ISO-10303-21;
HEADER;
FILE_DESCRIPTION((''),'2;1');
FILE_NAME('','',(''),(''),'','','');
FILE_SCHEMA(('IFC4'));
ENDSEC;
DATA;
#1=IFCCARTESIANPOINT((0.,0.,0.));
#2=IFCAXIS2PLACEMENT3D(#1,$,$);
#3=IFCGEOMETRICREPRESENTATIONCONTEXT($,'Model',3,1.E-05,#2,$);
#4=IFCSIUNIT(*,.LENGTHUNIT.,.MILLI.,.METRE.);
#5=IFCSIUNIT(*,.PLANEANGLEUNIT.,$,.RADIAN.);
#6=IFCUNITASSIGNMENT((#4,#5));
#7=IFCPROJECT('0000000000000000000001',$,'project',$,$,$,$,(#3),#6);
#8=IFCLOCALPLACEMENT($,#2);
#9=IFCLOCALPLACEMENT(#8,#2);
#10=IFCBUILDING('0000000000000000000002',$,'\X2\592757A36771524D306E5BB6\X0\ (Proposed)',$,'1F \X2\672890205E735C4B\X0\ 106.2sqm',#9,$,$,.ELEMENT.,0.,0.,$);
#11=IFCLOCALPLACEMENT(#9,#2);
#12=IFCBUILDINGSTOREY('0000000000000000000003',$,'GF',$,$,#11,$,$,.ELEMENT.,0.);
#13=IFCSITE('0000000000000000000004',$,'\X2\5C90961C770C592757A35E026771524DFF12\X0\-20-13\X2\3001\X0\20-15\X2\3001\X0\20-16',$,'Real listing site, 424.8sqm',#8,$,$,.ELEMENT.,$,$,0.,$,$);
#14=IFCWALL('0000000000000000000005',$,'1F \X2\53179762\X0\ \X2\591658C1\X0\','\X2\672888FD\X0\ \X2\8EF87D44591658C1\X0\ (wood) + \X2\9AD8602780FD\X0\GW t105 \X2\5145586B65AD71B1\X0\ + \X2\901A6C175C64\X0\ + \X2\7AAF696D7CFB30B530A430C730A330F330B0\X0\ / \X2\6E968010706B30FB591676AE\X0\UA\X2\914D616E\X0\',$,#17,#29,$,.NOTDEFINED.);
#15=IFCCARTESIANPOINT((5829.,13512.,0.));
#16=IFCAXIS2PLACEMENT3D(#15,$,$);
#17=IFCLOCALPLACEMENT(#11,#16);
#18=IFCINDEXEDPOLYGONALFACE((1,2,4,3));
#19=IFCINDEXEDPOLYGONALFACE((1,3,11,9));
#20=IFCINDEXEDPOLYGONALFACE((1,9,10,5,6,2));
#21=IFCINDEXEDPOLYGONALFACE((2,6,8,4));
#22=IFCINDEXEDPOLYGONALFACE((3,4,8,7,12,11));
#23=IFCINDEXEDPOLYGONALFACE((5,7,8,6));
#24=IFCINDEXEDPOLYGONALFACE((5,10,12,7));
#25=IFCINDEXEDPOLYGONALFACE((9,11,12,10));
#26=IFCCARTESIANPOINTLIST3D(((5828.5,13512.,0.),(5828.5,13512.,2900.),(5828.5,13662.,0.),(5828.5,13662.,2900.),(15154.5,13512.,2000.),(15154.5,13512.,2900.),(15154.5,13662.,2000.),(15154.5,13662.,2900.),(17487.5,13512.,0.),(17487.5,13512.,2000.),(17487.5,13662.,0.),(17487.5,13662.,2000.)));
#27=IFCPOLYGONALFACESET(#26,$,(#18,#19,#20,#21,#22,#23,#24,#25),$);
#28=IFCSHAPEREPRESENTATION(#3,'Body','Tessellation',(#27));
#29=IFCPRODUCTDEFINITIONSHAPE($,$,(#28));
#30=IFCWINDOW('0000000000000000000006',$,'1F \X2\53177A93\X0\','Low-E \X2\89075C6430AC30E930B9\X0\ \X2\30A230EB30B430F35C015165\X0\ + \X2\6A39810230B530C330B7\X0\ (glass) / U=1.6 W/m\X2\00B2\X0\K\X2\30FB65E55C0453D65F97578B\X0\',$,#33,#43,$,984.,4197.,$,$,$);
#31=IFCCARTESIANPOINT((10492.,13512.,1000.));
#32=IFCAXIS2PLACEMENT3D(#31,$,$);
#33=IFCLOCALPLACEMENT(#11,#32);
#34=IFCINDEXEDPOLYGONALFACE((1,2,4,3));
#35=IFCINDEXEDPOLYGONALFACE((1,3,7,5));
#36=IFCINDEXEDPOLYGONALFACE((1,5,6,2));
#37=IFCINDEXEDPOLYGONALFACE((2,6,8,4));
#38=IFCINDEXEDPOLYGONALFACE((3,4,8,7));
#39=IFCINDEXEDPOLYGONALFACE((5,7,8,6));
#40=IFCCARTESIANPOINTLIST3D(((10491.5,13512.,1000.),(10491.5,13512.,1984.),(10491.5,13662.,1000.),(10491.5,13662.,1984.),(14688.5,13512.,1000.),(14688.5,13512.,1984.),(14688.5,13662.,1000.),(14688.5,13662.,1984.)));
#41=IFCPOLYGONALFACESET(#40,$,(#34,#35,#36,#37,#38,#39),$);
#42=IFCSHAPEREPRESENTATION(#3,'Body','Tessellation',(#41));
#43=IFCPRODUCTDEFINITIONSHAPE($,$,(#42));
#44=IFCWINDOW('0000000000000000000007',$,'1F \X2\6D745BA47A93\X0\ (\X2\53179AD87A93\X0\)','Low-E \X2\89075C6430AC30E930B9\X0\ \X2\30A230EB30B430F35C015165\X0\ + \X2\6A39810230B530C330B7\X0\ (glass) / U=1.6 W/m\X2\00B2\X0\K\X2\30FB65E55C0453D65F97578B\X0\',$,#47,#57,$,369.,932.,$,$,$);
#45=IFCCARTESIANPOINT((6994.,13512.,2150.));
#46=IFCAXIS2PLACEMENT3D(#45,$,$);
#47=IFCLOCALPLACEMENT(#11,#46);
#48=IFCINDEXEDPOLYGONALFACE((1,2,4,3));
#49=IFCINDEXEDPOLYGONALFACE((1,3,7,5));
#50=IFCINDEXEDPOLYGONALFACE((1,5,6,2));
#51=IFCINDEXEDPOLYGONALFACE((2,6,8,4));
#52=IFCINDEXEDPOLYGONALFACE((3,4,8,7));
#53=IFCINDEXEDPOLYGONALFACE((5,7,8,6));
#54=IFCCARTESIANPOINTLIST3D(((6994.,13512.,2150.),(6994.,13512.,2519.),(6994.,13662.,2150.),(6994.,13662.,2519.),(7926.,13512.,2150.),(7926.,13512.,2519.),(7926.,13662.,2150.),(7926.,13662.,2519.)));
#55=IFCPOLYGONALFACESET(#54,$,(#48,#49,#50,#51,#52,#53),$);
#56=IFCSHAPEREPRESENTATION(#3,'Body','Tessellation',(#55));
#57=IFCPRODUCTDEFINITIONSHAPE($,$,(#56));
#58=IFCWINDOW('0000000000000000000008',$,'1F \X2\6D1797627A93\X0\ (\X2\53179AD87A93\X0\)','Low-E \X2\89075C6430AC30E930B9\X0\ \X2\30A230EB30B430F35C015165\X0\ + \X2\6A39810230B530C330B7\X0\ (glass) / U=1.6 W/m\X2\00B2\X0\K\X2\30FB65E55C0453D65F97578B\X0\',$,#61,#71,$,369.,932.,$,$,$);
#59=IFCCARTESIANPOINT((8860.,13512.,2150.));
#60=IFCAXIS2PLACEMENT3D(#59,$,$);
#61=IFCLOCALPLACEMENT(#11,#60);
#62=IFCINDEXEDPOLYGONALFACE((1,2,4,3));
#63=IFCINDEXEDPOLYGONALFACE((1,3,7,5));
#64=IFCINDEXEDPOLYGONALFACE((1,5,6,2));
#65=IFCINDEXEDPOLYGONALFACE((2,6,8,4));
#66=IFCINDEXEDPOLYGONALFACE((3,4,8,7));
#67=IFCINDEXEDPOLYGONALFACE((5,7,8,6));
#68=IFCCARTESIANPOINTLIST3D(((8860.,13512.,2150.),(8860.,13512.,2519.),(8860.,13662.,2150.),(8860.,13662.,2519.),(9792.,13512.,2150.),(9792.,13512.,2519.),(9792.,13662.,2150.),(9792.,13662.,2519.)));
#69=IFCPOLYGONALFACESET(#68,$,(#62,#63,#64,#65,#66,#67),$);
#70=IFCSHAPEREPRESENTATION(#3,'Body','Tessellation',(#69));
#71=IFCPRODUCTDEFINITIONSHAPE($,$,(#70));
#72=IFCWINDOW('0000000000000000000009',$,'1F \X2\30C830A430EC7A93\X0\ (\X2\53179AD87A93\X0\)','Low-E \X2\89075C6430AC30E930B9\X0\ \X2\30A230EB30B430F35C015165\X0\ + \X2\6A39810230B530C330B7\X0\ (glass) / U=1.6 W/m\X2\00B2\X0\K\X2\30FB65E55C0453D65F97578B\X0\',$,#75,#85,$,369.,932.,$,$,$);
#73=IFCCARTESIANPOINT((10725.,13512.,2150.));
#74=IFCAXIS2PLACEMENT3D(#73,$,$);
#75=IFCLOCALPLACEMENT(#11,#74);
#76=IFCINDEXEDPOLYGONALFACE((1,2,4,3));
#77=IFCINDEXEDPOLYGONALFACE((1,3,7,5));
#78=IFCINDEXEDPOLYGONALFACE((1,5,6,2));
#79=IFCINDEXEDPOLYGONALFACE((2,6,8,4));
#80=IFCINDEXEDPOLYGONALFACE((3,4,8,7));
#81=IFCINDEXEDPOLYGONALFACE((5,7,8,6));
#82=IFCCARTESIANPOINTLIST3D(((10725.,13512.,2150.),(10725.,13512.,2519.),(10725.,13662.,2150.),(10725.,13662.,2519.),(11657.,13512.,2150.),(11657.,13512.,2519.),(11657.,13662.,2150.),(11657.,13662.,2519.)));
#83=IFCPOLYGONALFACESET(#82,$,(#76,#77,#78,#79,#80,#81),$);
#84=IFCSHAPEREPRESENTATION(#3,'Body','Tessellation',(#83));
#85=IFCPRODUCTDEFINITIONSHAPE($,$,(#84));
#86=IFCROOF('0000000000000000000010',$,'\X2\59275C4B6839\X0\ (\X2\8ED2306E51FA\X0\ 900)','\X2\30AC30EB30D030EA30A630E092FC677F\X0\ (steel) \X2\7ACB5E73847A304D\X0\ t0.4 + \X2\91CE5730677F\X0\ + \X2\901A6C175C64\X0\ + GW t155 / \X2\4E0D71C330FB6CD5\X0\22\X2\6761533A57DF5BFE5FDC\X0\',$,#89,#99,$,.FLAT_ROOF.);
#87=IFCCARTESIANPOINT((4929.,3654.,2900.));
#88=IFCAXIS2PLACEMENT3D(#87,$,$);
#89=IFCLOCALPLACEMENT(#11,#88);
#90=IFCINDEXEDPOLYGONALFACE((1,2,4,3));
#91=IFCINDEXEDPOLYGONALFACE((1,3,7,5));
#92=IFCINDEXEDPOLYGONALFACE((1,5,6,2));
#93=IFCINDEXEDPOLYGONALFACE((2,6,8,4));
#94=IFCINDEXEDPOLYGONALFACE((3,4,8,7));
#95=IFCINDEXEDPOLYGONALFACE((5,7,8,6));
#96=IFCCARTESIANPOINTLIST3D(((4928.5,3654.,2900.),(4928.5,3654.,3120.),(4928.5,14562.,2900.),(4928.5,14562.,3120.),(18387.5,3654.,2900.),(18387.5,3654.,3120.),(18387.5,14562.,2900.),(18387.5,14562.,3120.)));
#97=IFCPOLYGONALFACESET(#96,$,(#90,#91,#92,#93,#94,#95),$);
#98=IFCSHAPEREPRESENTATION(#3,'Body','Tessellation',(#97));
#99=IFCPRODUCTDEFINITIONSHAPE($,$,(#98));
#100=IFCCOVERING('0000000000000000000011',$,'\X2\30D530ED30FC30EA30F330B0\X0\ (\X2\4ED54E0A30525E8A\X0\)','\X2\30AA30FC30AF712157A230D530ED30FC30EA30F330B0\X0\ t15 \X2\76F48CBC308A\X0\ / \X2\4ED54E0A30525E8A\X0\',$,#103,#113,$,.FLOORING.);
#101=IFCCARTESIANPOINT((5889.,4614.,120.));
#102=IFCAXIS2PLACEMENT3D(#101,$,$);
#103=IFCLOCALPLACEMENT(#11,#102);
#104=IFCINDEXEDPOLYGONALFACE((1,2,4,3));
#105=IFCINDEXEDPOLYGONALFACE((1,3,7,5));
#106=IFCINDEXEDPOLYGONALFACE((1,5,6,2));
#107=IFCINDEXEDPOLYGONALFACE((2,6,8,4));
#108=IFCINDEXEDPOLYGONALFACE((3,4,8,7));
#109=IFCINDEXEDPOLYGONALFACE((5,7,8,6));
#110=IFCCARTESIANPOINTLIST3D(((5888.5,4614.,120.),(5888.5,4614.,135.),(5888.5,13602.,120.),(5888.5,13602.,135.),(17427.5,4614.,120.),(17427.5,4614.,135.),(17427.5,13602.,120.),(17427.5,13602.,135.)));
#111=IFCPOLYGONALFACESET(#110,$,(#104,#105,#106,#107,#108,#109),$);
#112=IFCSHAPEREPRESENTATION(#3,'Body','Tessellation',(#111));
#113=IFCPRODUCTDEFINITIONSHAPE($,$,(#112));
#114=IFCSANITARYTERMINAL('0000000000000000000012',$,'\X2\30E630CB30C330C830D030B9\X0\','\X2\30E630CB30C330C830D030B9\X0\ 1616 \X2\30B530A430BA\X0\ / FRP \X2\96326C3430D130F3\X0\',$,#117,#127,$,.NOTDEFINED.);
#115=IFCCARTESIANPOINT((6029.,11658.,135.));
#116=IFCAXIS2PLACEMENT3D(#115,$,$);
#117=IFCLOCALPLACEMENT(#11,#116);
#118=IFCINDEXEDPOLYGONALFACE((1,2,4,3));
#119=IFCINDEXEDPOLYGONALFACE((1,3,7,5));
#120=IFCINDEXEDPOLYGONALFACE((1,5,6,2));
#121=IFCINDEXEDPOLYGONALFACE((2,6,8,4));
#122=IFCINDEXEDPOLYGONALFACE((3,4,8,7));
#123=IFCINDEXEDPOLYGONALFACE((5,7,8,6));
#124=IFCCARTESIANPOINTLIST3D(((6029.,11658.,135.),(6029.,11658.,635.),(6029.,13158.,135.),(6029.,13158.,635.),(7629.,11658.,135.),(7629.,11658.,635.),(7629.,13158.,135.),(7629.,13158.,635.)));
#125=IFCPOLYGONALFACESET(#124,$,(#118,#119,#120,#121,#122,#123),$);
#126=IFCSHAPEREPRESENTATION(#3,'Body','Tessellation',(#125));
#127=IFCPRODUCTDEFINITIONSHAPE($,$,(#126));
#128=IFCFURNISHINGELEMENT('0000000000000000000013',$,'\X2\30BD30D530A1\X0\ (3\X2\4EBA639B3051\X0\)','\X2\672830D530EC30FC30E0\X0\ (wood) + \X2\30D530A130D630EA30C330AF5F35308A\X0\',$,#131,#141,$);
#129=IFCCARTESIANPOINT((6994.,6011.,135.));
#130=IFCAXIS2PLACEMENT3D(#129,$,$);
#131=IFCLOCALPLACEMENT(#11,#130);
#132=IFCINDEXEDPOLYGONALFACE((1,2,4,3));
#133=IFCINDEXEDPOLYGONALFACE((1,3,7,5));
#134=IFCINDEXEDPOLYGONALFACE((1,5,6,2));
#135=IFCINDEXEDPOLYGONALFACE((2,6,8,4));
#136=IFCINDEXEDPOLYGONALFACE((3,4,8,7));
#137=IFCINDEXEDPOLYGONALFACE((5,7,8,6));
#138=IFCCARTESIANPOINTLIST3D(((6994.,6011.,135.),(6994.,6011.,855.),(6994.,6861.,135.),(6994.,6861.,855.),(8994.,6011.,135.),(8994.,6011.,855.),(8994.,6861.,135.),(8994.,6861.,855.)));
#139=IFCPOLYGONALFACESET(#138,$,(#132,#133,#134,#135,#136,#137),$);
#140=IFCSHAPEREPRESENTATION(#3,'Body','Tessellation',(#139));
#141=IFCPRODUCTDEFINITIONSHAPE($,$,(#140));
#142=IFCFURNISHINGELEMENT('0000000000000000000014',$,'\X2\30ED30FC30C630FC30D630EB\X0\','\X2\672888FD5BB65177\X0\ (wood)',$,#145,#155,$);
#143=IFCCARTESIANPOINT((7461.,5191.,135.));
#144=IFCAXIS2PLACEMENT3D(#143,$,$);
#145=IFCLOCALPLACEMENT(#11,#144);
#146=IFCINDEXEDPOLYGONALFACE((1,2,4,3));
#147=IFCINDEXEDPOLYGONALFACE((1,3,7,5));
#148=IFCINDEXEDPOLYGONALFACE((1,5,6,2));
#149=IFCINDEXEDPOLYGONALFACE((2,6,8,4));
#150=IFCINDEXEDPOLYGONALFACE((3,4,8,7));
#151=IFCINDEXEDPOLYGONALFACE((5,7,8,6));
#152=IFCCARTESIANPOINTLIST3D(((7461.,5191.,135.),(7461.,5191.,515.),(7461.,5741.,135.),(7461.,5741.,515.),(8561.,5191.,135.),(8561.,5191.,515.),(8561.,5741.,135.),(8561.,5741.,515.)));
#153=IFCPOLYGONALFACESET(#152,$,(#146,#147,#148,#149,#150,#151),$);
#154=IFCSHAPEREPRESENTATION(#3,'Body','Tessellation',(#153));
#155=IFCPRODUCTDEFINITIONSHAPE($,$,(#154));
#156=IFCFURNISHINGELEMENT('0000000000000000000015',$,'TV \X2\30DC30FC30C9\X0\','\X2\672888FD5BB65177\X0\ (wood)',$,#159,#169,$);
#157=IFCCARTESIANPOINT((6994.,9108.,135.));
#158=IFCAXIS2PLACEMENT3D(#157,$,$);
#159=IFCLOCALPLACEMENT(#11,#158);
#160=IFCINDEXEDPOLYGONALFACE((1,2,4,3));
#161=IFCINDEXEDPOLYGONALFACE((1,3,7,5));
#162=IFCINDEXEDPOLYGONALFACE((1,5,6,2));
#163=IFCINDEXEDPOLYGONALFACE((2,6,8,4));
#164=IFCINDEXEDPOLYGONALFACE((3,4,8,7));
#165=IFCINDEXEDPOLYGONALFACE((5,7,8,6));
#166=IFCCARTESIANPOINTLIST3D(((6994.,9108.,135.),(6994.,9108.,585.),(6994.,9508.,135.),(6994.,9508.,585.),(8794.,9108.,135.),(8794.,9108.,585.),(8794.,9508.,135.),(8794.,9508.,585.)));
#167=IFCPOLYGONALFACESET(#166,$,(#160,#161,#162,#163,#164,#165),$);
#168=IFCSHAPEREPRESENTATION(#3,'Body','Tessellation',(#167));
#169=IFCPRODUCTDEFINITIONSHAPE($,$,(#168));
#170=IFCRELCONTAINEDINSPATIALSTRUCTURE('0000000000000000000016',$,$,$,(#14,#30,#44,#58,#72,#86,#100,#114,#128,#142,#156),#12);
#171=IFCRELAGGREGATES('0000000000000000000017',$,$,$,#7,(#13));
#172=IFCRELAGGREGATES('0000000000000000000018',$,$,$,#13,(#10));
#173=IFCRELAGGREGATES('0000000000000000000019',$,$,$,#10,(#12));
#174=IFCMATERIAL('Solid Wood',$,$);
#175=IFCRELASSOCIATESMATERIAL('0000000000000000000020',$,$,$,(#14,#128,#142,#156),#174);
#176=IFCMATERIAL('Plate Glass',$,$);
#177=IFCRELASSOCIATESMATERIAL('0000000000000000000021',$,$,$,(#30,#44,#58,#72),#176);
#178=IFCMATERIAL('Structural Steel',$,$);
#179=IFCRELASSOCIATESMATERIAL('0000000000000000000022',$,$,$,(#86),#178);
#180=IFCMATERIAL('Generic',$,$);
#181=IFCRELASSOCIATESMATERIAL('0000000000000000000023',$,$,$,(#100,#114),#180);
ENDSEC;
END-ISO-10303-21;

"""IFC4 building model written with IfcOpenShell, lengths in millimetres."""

from ifc_helpers import new_model, si_unit, frame, frame_2d, origin, place, context, project, spatial, rectangle, extrude, material, element, fill, save


model = new_model("IFC4")

# Units and contexts
model_context = context("Model", 3, precision=1e-05, world=origin())
ifc_project = project(units=[si_unit("LENGTHUNIT", "METRE", prefix="MILLI"), si_unit("PLANEANGLEUNIT", "RADIAN")], contexts=[model_context])

# Site, building, storey
site_placement = place(None, origin())
site = spatial("IfcSite", under=ifc_project, at=site_placement, Name="岐阜県大垣市東前２-20-13、20-15、20-16", ObjectType="Real listing site, 424.8sqm", CompositionType="ELEMENT", RefElevation=0.0)
building_placement = place(site_placement, origin())
building = spatial("IfcBuilding", under=site, at=building_placement, Name="大垣東前の家 (Proposed)", ObjectType="1F 木造平屋 106.2sqm", CompositionType="ELEMENT", ElevationOfRefHeight=0.0, ElevationOfTerrain=0.0)
storey_placement = place(building_placement, origin())
storey = spatial("IfcBuildingStorey", under=building, at=storey_placement, Name="GF", CompositionType="ELEMENT", Elevation=0.0)

# Shared definitions
ifc_material_1 = material(Name="Solid Wood")

# Shared definitions
ifc_material_2 = material(Name="Plate Glass")

# Wall, openings, windows
wall_1_placement = place(storey_placement, frame((5829.0, 13512.0, 0.0)))
wall_1 = element("IfcWall", 1, at=wall_1_placement, inside=storey, material=ifc_material_1, Name="1F 北面 外壁", Description="木製 軸組外壁 (wood) + 高性能GW t105 充填断熱 + 通気層 + 窯業系サイディング / 準耐火・外皮UA配慮", PredefinedType="NOTDEFINED", context=model_context, shape_type="SweptSolid", body=[
    extrude(rectangle(XDim=11659.0, YDim=150.0, at=frame_2d((5829.0, 75.0))), frame((5829.0, 13512.0, 0.0)), (0.0, 0.0, 1.0), 2900.0),
])
opening_1_placement = place(storey_placement, frame((10492.0, 13512.0, 1000.0)))
opening_1 = element("IfcOpeningElement", 2, at=opening_1_placement, cuts=wall_1, PredefinedType="NOTDEFINED", context=model_context, shape_type="SweptSolid", body=[
    extrude(rectangle(XDim=4197.0, YDim=150.0, at=frame_2d((2098.0, 75.0))), frame((10492.0, 13512.0, 1000.0)), (0.0, 0.0, 1.0), 984.0),
])
opening_2_placement = place(storey_placement, frame((6994.0, 13512.0, 2150.0)))
opening_2 = element("IfcOpeningElement", 3, at=opening_2_placement, cuts=wall_1, PredefinedType="NOTDEFINED", context=model_context, shape_type="SweptSolid", body=[
    extrude(rectangle(XDim=932.0, YDim=150.0, at=frame_2d((466.0, 75.0))), frame((6994.0, 13512.0, 2150.0)), (0.0, 0.0, 1.0), 369.0),
])
opening_3_placement = place(storey_placement, frame((8860.0, 13512.0, 2150.0)))
opening_3 = element("IfcOpeningElement", 4, at=opening_3_placement, cuts=wall_1, PredefinedType="NOTDEFINED", context=model_context, shape_type="SweptSolid", body=[
    extrude(rectangle(XDim=932.0, YDim=150.0, at=frame_2d((466.0, 75.0))), frame((8860.0, 13512.0, 2150.0)), (0.0, 0.0, 1.0), 369.0),
])
opening_4_placement = place(storey_placement, frame((10725.0, 13512.0, 2150.0)))
opening_4 = element("IfcOpeningElement", 5, at=opening_4_placement, cuts=wall_1, PredefinedType="NOTDEFINED", context=model_context, shape_type="SweptSolid", body=[
    extrude(rectangle(XDim=932.0, YDim=150.0, at=frame_2d((466.0, 75.0))), frame((10725.0, 13512.0, 2150.0)), (0.0, 0.0, 1.0), 369.0),
])
window_1_placement = place(storey_placement, frame((10492.0, 13512.0, 1000.0)))
window_1 = element("IfcWindow", 6, at=window_1_placement, inside=storey, material=ifc_material_2, Name="1F 北窓", Description="Low-E 複層ガラス アルゴン封入 + 樹脂サッシ (glass) / U=1.6 W/m²K・日射取得型", OverallHeight=984.0, OverallWidth=4197.0, context=model_context, shape_type="SweptSolid", body=[
    extrude(rectangle(XDim=4197.0, YDim=150.0, at=frame_2d((2098.0, 75.0))), frame((10492.0, 13512.0, 1000.0)), (0.0, 0.0, 1.0), 984.0),
])
fill(opening_1, window_1)
window_2_placement = place(storey_placement, frame((6994.0, 13512.0, 2150.0)))
window_2 = element("IfcWindow", 7, at=window_2_placement, inside=storey, material=ifc_material_2, Name="1F 浴室窓 (北高窓)", Description="Low-E 複層ガラス アルゴン封入 + 樹脂サッシ (glass) / U=1.6 W/m²K・日射取得型", OverallHeight=369.0, OverallWidth=932.0, context=model_context, shape_type="SweptSolid", body=[
    extrude(rectangle(XDim=932.0, YDim=150.0, at=frame_2d((466.0, 75.0))), frame((6994.0, 13512.0, 2150.0)), (0.0, 0.0, 1.0), 369.0),
])
fill(opening_2, window_2)
window_3_placement = place(storey_placement, frame((8860.0, 13512.0, 2150.0)))
window_3 = element("IfcWindow", 8, at=window_3_placement, inside=storey, material=ifc_material_2, Name="1F 洗面窓 (北高窓)", Description="Low-E 複層ガラス アルゴン封入 + 樹脂サッシ (glass) / U=1.6 W/m²K・日射取得型", OverallHeight=369.0, OverallWidth=932.0, context=model_context, shape_type="SweptSolid", body=[
    extrude(rectangle(XDim=932.0, YDim=150.0, at=frame_2d((466.0, 75.0))), frame((8860.0, 13512.0, 2150.0)), (0.0, 0.0, 1.0), 369.0),
])
fill(opening_3, window_3)
window_4_placement = place(storey_placement, frame((10725.0, 13512.0, 2150.0)))
window_4 = element("IfcWindow", 9, at=window_4_placement, inside=storey, material=ifc_material_2, Name="1F トイレ窓 (北高窓)", Description="Low-E 複層ガラス アルゴン封入 + 樹脂サッシ (glass) / U=1.6 W/m²K・日射取得型", OverallHeight=369.0, OverallWidth=932.0, context=model_context, shape_type="SweptSolid", body=[
    extrude(rectangle(XDim=932.0, YDim=150.0, at=frame_2d((466.0, 75.0))), frame((10725.0, 13512.0, 2150.0)), (0.0, 0.0, 1.0), 369.0),
])
fill(opening_4, window_4)

# Roof
ifc_material_3 = material(Name="Structural Steel")
roof_placement = place(storey_placement, frame((4929.0, 3654.0, 2900.0)))
element("IfcRoof", 10, at=roof_placement, inside=storey, material=ifc_material_3, Name="大屋根 (軒の出 900)", Description="ガルバリウム鋼板 (steel) 立平葺き t0.4 + 野地板 + 通気層 + GW t155 / 不燃・法22条区域対応", PredefinedType="FLAT_ROOF", context=model_context, shape_type="SweptSolid", body=[
    extrude(rectangle(XDim=13459.0, YDim=10908.0, at=frame_2d((6729.0, 5454.0))), frame((4929.0, 3654.0, 2900.0)), (0.0, 0.0, 1.0), 220.0),
])

# Covering
ifc_material_4 = material(Name="Generic")
covering_placement = place(storey_placement, frame((5889.0, 4614.0, 120.0)))
element("IfcCovering", 11, at=covering_placement, inside=storey, material=ifc_material_4, Name="フローリング (仕上げ床)", Description="オーク無垢フローリング t15 直貼り / 仕上げ床", PredefinedType="FLOORING", context=model_context, shape_type="SweptSolid", body=[
    extrude(rectangle(XDim=11539.0, YDim=8988.0, at=frame_2d((5769.0, 4494.0))), frame((5889.0, 4614.0, 120.0)), (0.0, 0.0, 1.0), 15.0),
])

# Sanitary terminal
sanitary_terminal_placement = place(storey_placement, frame((6029.0, 11658.0, 135.0)))
element("IfcSanitaryTerminal", 12, at=sanitary_terminal_placement, inside=storey, material=ifc_material_4, Name="ユニットバス", Description="ユニットバス 1616 サイズ / FRP 防水パン", PredefinedType="NOTDEFINED", context=model_context, shape_type="SweptSolid", body=[
    extrude(rectangle(XDim=1600.0, YDim=1500.0, at=frame_2d((800.0, 750.0))), frame((6029.0, 11658.0, 135.0)), (0.0, 0.0, 1.0), 500.0),
])

# Furnishing elements
furnishing_1_placement = place(storey_placement, frame((6994.0, 6011.0, 135.0)))
element("IfcFurnishingElement", 13, at=furnishing_1_placement, inside=storey, material=ifc_material_1, Name="ソファ (3人掛け)", Description="木フレーム (wood) + ファブリック張り", context=model_context, shape_type="SweptSolid", body=[
    extrude(rectangle(XDim=2000.0, YDim=850.0, at=frame_2d((1000.0, 425.0))), frame((6994.0, 6011.0, 135.0)), (0.0, 0.0, 1.0), 720.0),
])
furnishing_2_placement = place(storey_placement, frame((7461.0, 5191.0, 135.0)))
element("IfcFurnishingElement", 14, at=furnishing_2_placement, inside=storey, material=ifc_material_1, Name="ローテーブル", Description="木製家具 (wood)", context=model_context, shape_type="SweptSolid", body=[
    extrude(rectangle(XDim=1100.0, YDim=550.0, at=frame_2d((550.0, 275.0))), frame((7461.0, 5191.0, 135.0)), (0.0, 0.0, 1.0), 380.0),
])
furnishing_3_placement = place(storey_placement, frame((6994.0, 9108.0, 135.0)))
element("IfcFurnishingElement", 15, at=furnishing_3_placement, inside=storey, material=ifc_material_1, Name="TV ボード", Description="木製家具 (wood)", context=model_context, shape_type="SweptSolid", body=[
    extrude(rectangle(XDim=1800.0, YDim=400.0, at=frame_2d((900.0, 200.0))), frame((6994.0, 9108.0, 135.0)), (0.0, 0.0, 1.0), 450.0),
])

save(model, "model.ifc")
